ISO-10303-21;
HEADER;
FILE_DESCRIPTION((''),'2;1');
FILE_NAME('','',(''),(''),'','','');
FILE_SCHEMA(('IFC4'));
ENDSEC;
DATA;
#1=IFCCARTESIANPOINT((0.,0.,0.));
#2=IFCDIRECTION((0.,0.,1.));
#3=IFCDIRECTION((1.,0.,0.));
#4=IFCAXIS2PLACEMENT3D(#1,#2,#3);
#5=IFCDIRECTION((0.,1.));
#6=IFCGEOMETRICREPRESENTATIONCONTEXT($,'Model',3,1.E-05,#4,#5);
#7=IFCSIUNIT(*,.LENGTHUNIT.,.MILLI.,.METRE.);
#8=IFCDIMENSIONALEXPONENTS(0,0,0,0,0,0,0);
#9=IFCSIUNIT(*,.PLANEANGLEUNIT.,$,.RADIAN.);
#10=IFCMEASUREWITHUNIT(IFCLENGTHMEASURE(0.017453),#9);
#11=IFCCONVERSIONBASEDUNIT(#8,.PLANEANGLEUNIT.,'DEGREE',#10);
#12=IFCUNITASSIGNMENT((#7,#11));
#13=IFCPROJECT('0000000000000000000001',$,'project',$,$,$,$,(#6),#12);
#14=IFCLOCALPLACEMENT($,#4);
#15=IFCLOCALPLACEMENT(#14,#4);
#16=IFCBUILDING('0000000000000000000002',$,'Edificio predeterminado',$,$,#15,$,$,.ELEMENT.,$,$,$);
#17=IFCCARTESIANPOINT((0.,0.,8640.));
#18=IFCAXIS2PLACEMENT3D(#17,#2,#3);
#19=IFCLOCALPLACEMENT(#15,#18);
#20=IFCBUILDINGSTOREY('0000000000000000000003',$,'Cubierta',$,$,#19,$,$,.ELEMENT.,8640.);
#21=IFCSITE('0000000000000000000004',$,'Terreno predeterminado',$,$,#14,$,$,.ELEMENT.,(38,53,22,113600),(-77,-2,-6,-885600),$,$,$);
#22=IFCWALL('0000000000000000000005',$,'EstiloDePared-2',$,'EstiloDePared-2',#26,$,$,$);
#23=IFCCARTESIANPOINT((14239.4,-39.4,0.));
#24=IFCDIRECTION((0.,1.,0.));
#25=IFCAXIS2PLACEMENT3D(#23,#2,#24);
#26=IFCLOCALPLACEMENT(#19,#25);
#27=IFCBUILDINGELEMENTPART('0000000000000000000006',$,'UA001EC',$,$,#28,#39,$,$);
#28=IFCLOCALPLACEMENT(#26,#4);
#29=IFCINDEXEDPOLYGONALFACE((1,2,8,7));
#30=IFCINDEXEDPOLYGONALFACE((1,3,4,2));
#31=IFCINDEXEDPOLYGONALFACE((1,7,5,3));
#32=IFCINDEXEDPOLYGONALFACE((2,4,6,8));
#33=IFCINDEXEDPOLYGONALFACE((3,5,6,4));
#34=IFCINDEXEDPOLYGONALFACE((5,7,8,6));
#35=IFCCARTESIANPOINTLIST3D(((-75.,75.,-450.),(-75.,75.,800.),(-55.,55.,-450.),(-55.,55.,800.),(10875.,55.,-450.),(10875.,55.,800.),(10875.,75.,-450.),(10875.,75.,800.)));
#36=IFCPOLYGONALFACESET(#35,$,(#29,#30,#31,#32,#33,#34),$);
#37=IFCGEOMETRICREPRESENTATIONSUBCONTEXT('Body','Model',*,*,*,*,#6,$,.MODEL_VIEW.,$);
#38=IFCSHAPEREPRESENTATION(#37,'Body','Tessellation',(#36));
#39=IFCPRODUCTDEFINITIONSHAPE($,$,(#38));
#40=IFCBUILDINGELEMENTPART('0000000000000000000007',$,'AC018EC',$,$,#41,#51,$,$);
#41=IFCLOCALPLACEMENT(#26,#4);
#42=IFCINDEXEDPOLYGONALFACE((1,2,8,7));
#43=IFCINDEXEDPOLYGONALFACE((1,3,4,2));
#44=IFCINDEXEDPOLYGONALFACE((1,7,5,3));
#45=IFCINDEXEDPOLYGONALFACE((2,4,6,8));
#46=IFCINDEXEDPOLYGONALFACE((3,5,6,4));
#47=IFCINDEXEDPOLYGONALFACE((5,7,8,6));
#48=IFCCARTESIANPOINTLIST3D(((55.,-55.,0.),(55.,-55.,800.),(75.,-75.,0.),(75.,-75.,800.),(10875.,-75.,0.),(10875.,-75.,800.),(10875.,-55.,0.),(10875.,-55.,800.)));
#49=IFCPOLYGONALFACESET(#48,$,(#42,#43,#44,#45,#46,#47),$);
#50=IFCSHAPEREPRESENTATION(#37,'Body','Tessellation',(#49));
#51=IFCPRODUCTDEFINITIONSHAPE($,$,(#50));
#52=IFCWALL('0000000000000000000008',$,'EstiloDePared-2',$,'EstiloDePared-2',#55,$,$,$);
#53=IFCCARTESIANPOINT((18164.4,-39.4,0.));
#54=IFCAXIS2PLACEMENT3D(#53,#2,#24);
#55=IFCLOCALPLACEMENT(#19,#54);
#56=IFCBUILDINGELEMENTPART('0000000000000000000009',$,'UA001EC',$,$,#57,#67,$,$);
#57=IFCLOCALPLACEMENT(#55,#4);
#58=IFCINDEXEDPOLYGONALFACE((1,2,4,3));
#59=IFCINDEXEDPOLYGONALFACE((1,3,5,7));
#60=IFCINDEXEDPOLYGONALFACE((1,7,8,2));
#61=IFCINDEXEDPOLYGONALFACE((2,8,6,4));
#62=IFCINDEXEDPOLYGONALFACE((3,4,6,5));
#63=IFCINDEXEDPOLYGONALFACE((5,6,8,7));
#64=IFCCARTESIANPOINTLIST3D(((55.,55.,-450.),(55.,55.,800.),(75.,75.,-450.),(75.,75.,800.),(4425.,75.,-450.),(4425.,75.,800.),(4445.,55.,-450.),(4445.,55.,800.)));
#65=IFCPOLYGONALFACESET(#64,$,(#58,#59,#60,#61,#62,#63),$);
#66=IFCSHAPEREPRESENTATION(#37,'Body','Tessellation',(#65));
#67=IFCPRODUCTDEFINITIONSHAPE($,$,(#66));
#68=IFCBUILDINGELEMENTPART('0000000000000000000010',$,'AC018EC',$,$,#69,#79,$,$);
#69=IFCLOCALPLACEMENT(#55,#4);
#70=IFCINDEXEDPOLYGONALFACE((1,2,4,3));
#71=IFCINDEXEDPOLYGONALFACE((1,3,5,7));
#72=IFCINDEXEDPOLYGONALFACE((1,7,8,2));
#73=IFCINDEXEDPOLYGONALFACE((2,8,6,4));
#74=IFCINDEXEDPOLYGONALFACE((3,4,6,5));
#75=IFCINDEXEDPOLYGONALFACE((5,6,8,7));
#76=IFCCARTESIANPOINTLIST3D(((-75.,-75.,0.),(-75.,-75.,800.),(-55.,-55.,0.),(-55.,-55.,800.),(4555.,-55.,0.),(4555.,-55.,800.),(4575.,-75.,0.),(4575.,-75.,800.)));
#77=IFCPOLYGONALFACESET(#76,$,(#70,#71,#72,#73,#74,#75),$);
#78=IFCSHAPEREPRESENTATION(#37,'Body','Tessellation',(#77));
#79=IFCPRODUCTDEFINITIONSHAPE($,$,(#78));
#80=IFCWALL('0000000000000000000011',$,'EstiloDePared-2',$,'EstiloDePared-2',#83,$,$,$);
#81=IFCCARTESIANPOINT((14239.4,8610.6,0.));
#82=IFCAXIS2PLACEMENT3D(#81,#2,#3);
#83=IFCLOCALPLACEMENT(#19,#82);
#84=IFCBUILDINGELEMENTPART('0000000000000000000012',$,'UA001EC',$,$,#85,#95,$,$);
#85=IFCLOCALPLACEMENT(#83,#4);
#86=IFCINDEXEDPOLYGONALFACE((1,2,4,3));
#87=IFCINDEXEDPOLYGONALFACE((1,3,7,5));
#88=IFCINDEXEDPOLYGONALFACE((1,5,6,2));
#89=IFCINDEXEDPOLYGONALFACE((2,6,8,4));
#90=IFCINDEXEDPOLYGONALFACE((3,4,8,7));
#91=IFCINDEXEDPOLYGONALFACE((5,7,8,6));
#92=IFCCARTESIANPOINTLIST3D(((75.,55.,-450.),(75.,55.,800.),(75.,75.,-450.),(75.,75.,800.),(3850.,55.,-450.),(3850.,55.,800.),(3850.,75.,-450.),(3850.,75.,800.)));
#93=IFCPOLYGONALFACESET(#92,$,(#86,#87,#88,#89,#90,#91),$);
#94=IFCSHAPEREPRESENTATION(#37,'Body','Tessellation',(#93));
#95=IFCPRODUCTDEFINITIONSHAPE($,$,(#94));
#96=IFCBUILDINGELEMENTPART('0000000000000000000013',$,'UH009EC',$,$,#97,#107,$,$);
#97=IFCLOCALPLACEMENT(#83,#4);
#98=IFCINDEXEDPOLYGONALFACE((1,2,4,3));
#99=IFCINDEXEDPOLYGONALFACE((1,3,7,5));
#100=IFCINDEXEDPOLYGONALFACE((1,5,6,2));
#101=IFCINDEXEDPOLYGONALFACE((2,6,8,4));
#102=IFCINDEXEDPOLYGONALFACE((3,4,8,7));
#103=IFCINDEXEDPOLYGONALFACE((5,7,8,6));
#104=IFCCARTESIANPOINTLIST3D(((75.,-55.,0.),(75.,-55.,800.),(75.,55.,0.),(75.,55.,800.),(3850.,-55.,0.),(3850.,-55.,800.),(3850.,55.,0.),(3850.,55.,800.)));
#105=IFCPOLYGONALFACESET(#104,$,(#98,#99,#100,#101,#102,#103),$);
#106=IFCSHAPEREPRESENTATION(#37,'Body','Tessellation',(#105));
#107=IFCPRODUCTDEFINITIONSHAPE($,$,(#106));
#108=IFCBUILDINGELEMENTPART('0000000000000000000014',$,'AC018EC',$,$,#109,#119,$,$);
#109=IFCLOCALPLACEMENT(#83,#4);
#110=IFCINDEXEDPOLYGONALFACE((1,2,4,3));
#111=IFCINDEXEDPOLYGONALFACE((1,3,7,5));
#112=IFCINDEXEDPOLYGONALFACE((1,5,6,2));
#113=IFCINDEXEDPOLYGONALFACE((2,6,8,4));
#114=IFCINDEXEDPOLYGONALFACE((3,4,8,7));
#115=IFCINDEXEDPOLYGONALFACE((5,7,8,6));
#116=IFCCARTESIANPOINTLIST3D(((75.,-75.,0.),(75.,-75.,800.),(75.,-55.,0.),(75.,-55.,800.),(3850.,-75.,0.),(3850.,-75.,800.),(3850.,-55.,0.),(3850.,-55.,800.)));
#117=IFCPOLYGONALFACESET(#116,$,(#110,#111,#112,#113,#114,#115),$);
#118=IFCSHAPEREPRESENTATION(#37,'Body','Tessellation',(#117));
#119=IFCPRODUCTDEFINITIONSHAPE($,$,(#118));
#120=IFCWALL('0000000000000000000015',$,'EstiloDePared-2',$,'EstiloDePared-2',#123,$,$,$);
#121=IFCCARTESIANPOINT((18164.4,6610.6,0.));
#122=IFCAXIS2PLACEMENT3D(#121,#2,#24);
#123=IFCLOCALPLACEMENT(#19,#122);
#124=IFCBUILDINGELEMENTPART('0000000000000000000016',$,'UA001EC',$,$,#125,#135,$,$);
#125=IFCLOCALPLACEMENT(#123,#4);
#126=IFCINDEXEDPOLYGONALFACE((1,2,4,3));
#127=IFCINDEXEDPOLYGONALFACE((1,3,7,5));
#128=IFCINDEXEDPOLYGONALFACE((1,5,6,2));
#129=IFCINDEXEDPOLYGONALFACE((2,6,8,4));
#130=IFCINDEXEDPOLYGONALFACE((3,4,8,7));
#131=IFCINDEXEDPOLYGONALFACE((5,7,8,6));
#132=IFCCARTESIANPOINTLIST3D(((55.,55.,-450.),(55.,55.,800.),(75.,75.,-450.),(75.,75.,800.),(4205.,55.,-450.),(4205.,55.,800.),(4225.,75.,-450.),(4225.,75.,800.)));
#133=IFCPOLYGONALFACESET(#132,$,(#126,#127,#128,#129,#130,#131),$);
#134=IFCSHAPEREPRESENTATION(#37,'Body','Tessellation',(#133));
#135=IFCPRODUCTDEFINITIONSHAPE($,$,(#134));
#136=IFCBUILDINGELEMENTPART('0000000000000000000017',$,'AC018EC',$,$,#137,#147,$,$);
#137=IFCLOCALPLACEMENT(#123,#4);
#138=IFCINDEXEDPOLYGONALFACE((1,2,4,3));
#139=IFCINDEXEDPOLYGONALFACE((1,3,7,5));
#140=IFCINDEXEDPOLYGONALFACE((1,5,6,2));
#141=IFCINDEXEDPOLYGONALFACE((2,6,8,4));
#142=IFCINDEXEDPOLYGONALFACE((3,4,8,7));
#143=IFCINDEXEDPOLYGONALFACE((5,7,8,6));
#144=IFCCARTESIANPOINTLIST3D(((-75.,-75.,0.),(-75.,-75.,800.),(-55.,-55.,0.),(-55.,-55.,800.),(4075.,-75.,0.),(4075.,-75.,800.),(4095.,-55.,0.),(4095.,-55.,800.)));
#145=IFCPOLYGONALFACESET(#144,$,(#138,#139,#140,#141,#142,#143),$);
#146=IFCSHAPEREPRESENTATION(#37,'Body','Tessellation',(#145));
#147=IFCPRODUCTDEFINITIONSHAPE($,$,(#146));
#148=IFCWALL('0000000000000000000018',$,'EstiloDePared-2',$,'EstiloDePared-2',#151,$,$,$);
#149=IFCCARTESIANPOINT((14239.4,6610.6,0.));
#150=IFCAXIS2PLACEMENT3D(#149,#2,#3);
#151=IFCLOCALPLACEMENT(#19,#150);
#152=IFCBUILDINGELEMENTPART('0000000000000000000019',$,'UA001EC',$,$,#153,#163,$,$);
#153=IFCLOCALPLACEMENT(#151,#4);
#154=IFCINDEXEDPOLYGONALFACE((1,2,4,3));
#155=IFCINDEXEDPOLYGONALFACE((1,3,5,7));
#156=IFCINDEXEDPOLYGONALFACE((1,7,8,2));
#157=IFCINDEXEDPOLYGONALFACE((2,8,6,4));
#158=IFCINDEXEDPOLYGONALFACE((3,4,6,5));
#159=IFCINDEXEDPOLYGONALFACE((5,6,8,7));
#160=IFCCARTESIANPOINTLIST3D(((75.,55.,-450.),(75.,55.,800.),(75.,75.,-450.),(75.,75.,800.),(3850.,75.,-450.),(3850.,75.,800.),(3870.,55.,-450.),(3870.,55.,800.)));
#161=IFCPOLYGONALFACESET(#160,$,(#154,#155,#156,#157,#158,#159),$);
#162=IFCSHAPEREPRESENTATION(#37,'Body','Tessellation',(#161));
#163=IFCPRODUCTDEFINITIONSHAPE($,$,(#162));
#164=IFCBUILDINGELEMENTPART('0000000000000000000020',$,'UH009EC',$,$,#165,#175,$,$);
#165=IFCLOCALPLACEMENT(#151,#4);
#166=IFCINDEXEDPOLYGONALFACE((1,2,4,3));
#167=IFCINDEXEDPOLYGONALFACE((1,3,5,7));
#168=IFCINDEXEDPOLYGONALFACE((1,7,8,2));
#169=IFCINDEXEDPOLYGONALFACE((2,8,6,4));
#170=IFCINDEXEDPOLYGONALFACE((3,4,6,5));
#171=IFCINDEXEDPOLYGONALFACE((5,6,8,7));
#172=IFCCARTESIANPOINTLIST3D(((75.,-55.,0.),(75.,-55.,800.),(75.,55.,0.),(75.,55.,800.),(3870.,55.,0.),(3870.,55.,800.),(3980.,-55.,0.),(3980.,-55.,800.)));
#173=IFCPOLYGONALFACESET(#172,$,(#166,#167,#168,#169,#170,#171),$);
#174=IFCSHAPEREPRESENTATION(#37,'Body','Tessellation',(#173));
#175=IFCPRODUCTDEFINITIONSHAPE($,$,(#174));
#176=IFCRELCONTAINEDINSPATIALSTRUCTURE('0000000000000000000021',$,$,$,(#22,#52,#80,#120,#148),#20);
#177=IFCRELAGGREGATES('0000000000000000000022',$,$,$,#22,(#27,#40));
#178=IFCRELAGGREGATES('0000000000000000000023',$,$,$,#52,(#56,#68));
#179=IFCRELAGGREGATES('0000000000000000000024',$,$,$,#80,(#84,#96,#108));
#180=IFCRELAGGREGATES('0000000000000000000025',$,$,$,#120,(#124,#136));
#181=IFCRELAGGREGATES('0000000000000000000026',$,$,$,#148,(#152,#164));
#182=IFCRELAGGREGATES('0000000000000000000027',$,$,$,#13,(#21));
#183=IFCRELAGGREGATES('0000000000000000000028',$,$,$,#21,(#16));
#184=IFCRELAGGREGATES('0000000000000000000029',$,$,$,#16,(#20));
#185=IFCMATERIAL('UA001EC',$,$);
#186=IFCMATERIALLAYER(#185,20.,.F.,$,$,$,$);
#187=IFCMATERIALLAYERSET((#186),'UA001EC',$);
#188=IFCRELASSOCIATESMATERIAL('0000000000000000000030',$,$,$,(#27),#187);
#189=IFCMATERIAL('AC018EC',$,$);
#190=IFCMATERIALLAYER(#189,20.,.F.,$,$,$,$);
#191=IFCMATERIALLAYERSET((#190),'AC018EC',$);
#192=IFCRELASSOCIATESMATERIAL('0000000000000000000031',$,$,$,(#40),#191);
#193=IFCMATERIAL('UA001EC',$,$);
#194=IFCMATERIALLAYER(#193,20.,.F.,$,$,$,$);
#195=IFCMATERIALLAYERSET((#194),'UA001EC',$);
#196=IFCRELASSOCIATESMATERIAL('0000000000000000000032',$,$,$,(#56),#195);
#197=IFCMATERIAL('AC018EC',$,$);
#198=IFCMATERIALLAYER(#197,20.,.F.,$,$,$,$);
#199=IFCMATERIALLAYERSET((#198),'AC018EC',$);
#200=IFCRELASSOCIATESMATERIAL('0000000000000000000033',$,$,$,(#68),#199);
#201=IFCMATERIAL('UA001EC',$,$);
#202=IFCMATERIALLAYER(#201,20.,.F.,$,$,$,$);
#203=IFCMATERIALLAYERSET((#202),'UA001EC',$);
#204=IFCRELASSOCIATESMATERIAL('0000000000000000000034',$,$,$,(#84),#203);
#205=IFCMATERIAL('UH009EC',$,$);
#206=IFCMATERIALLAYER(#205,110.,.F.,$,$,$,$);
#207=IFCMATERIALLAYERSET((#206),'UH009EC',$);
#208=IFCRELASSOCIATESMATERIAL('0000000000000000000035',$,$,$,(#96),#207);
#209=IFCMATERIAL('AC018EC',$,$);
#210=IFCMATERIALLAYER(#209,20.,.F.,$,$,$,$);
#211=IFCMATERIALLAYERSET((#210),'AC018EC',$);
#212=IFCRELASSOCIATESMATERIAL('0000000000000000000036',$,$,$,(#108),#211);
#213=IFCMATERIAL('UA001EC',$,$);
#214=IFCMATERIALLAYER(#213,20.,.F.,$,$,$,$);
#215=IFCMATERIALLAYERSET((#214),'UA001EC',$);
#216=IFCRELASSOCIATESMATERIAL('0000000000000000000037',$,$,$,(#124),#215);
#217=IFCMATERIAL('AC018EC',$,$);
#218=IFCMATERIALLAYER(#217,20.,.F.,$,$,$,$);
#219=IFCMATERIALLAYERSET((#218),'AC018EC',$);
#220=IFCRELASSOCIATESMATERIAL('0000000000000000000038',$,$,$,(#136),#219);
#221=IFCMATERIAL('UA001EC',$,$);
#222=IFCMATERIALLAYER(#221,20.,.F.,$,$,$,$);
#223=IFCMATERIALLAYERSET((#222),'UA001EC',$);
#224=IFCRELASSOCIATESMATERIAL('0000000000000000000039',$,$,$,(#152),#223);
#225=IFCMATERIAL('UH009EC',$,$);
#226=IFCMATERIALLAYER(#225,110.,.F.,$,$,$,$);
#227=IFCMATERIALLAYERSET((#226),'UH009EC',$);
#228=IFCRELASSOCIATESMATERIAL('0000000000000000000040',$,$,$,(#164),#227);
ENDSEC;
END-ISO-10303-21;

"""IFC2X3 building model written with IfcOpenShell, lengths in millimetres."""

from ifc_helpers import new_model, entity, si_unit, converted_unit, direction, frame, origin_with_axes, place, context, subcontext, project, spatial, polyline, outline, extrude, material, layer, layer_set, layer_usage, element, aggregate, save


model = new_model("IFC2X3")

# Units and contexts
model_context = context("Model", 3, precision=1e-05, world=origin_with_axes(), true_north=direction((0.0, 1.0)))
body_context = subcontext(model_context, "Body", "Model", "MODEL_VIEW")
ifc_project = project(units=[si_unit("LENGTHUNIT", "METRE", prefix="MILLI"), converted_unit("PLANEANGLEUNIT", "DEGREE", entity("IfcLengthMeasure", 0.017453), si_unit("PLANEANGLEUNIT", "RADIAN"), dimensions=[0, 0, 0, 0, 0, 0, 0])], contexts=[model_context])

# Site, building, storey
site_placement = place(None, origin_with_axes())
site = spatial("IfcSite", under=ifc_project, at=site_placement, Name="Terreno predeterminado", CompositionType="ELEMENT", RefLatitude=(38, 53, 22, 113600), RefLongitude=(-77, -2, -6, -885600))
building_placement = place(site_placement, origin_with_axes())
building = spatial("IfcBuilding", under=site, at=building_placement, Name="Edificio predeterminado", CompositionType="ELEMENT")
storey_placement = place(building_placement, frame((0.0, 0.0, 8640.0), z_axis=(0.0, 0.0, 1.0), x_axis=(1.0, 0.0, 0.0)))
storey = spatial("IfcBuildingStorey", under=building, at=storey_placement, Name="Cubierta", CompositionType="ELEMENT", Elevation=8640.0)

# Walls, building element parts
wall_1_placement = place(storey_placement, frame((14239.4, -39.4, 0.0), z_axis=(0.0, 0.0, 1.0), x_axis=(0.0, 1.0, 0.0)))
wall_1 = element("IfcWall", 1, at=wall_1_placement, inside=storey, Name="EstiloDePared-2", ObjectType="EstiloDePared-2")
ifc_material_1 = material(Name="UA001EC")
ifc_layer_1 = layer(ifc_material_1, 20.0, ventilated=False)
ifc_layer_set_1 = layer_set([ifc_layer_1], Name="UA001EC")
ifc_layer_usage_1 = layer_usage(ifc_layer_set_1, "AXIS2", "NEGATIVE", -75.0)
building_element_part_1_placement = place(wall_1_placement, origin_with_axes())
building_element_part_1 = element("IfcBuildingElementPart", 2, at=building_element_part_1_placement, material=ifc_layer_usage_1, Name="UA001EC", context=body_context, shape_type="SweptSolid", body=[
    extrude(outline(polyline([(10875.0, 75.0), (10875.0, 55.0), (-55.0, 55.0), (-75.0, 75.0), (10875.0, 75.0)])), frame((0.0, 0.0, -450.0), z_axis=(0.0, 0.0, 1.0), x_axis=(1.0, 0.0, 0.0)), (0.0, 0.0, 1.0), 1250.0),
])
ifc_material_2 = material(Name="AC018EC")
ifc_layer_2 = layer(ifc_material_2, 20.0, ventilated=False)
ifc_layer_set_2 = layer_set([ifc_layer_2], Name="AC018EC")
ifc_layer_usage_2 = layer_usage(ifc_layer_set_2, "AXIS2", "NEGATIVE", 55.0)
building_element_part_2_placement = place(wall_1_placement, origin_with_axes())
building_element_part_2 = element("IfcBuildingElementPart", 3, at=building_element_part_2_placement, material=ifc_layer_usage_2, Name="AC018EC", context=body_context, shape_type="SweptSolid", body=[
    extrude(outline(polyline([(10875.0, -55.0), (10875.0, -75.0), (75.0, -75.0), (55.0, -55.0), (10875.0, -55.0)])), origin_with_axes(), (0.0, 0.0, 1.0), 800.0),
])
aggregate(wall_1, [building_element_part_1, building_element_part_2])
wall_2_placement = place(storey_placement, frame((18164.4, -39.4, 0.0), z_axis=(0.0, 0.0, 1.0), x_axis=(0.0, 1.0, 0.0)))
wall_2 = element("IfcWall", 4, at=wall_2_placement, inside=storey, Name="EstiloDePared-2", ObjectType="EstiloDePared-2")
ifc_material_3 = material(Name="UA001EC")
ifc_layer_3 = layer(ifc_material_3, 20.0, ventilated=False)
ifc_layer_set_3 = layer_set([ifc_layer_3], Name="UA001EC")
ifc_layer_usage_3 = layer_usage(ifc_layer_set_3, "AXIS2", "NEGATIVE", -75.0)
building_element_part_3_placement = place(wall_2_placement, origin_with_axes())
building_element_part_3 = element("IfcBuildingElementPart", 5, at=building_element_part_3_placement, material=ifc_layer_usage_3, Name="UA001EC", context=body_context, shape_type="SweptSolid", body=[
    extrude(outline(polyline([(4425.0, 75.0), (4445.0, 55.0), (55.0, 55.0), (75.0, 75.0), (4425.0, 75.0)])), frame((0.0, 0.0, -450.0), z_axis=(0.0, 0.0, 1.0), x_axis=(1.0, 0.0, 0.0)), (0.0, 0.0, 1.0), 1250.0),
])
ifc_material_4 = material(Name="AC018EC")
ifc_layer_4 = layer(ifc_material_4, 20.0, ventilated=False)
ifc_layer_set_4 = layer_set([ifc_layer_4], Name="AC018EC")
ifc_layer_usage_4 = layer_usage(ifc_layer_set_4, "AXIS2", "NEGATIVE", 55.0)
building_element_part_4_placement = place(wall_2_placement, origin_with_axes())
building_element_part_4 = element("IfcBuildingElementPart", 6, at=building_element_part_4_placement, material=ifc_layer_usage_4, Name="AC018EC", context=body_context, shape_type="SweptSolid", body=[
    extrude(outline(polyline([(4555.0, -55.0), (4575.0, -75.0), (-75.0, -75.0), (-55.0, -55.0), (4555.0, -55.0)])), origin_with_axes(), (0.0, 0.0, 1.0), 800.0),
])
aggregate(wall_2, [building_element_part_3, building_element_part_4])
wall_3_placement = place(storey_placement, frame((14239.4, 8610.6, 0.0), z_axis=(0.0, 0.0, 1.0), x_axis=(1.0, 0.0, 0.0)))
wall_3 = element("IfcWall", 7, at=wall_3_placement, inside=storey, Name="EstiloDePared-2", ObjectType="EstiloDePared-2")
ifc_material_5 = material(Name="UA001EC")
ifc_layer_5 = layer(ifc_material_5, 20.0, ventilated=False)
ifc_layer_set_5 = layer_set([ifc_layer_5], Name="UA001EC")
ifc_layer_usage_5 = layer_usage(ifc_layer_set_5, "AXIS2", "NEGATIVE", -75.0)
building_element_part_5_placement = place(wall_3_placement, origin_with_axes())
building_element_part_5 = element("IfcBuildingElementPart", 8, at=building_element_part_5_placement, material=ifc_layer_usage_5, Name="UA001EC", context=body_context, shape_type="SweptSolid", body=[
    extrude(outline(polyline([(3850.0, 75.0), (3850.0, 55.0), (75.0, 55.0), (75.0, 75.0), (3850.0, 75.0)])), frame((0.0, 0.0, -450.0), z_axis=(0.0, 0.0, 1.0), x_axis=(1.0, 0.0, 0.0)), (0.0, 0.0, 1.0), 1250.0),
])
ifc_material_6 = material(Name="UH009EC")
ifc_layer_6 = layer(ifc_material_6, 110.0, ventilated=False)
ifc_layer_set_6 = layer_set([ifc_layer_6], Name="UH009EC")
ifc_layer_usage_6 = layer_usage(ifc_layer_set_6, "AXIS2", "NEGATIVE", -55.0)
building_element_part_6_placement = place(wall_3_placement, origin_with_axes())
building_element_part_6 = element("IfcBuildingElementPart", 9, at=building_element_part_6_placement, material=ifc_layer_usage_6, Name="UH009EC", context=body_context, shape_type="SweptSolid", body=[
    extrude(outline(polyline([(3850.0, 55.0), (3850.0, -55.0), (75.0, -55.0), (75.0, 55.0), (3850.0, 55.0)])), origin_with_axes(), (0.0, 0.0, 1.0), 800.0),
])
ifc_material_7 = material(Name="AC018EC")
ifc_layer_7 = layer(ifc_material_7, 20.0, ventilated=False)
ifc_layer_set_7 = layer_set([ifc_layer_7], Name="AC018EC")
ifc_layer_usage_7 = layer_usage(ifc_layer_set_7, "AXIS2", "NEGATIVE", 55.0)
building_element_part_7_placement = place(wall_3_placement, origin_with_axes())
building_element_part_7 = element("IfcBuildingElementPart", 10, at=building_element_part_7_placement, material=ifc_layer_usage_7, Name="AC018EC", context=body_context, shape_type="SweptSolid", body=[
    extrude(outline(polyline([(3850.0, -55.0), (3850.0, -75.0), (75.0, -75.0), (75.0, -55.0), (3850.0, -55.0)])), origin_with_axes(), (0.0, 0.0, 1.0), 800.0),
])
aggregate(wall_3, [building_element_part_5, building_element_part_6, building_element_part_7])
wall_4_placement = place(storey_placement, frame((18164.4, 6610.6, 0.0), z_axis=(0.0, 0.0, 1.0), x_axis=(0.0, 1.0, 0.0)))
wall_4 = element("IfcWall", 11, at=wall_4_placement, inside=storey, Name="EstiloDePared-2", ObjectType="EstiloDePared-2")
ifc_material_8 = material(Name="UA001EC")
ifc_layer_8 = layer(ifc_material_8, 20.0, ventilated=False)
ifc_layer_set_8 = layer_set([ifc_layer_8], Name="UA001EC")
ifc_layer_usage_8 = layer_usage(ifc_layer_set_8, "AXIS2", "NEGATIVE", -75.0)
building_element_part_8_placement = place(wall_4_placement, origin_with_axes())
building_element_part_8 = element("IfcBuildingElementPart", 12, at=building_element_part_8_placement, material=ifc_layer_usage_8, Name="UA001EC", context=body_context, shape_type="SweptSolid", body=[
    extrude(outline(polyline([(4225.0, 75.0), (4205.0, 55.0), (55.0, 55.0), (75.0, 75.0), (4225.0, 75.0)])), frame((0.0, 0.0, -450.0), z_axis=(0.0, 0.0, 1.0), x_axis=(1.0, 0.0, 0.0)), (0.0, 0.0, 1.0), 1250.0),
])
ifc_material_9 = material(Name="AC018EC")
ifc_layer_9 = layer(ifc_material_9, 20.0, ventilated=False)
ifc_layer_set_9 = layer_set([ifc_layer_9], Name="AC018EC")
ifc_layer_usage_9 = layer_usage(ifc_layer_set_9, "AXIS2", "NEGATIVE", 55.0)
building_element_part_9_placement = place(wall_4_placement, origin_with_axes())
building_element_part_9 = element("IfcBuildingElementPart", 13, at=building_element_part_9_placement, material=ifc_layer_usage_9, Name="AC018EC", context=body_context, shape_type="SweptSolid", body=[
    extrude(outline(polyline([(4095.0, -55.0), (4075.0, -75.0), (-75.0, -75.0), (-55.0, -55.0), (4095.0, -55.0)])), origin_with_axes(), (0.0, 0.0, 1.0), 800.0),
])
aggregate(wall_4, [building_element_part_8, building_element_part_9])
wall_5_placement = place(storey_placement, frame((14239.4, 6610.6, 0.0), z_axis=(0.0, 0.0, 1.0), x_axis=(1.0, 0.0, 0.0)))
wall_5 = element("IfcWall", 14, at=wall_5_placement, inside=storey, Name="EstiloDePared-2", ObjectType="EstiloDePared-2")
ifc_material_10 = material(Name="UA001EC")
ifc_layer_10 = layer(ifc_material_10, 20.0, ventilated=False)
ifc_layer_set_10 = layer_set([ifc_layer_10], Name="UA001EC")
ifc_layer_usage_10 = layer_usage(ifc_layer_set_10, "AXIS2", "NEGATIVE", -75.0)
building_element_part_10_placement = place(wall_5_placement, origin_with_axes())
building_element_part_10 = element("IfcBuildingElementPart", 15, at=building_element_part_10_placement, material=ifc_layer_usage_10, Name="UA001EC", context=body_context, shape_type="SweptSolid", body=[
    extrude(outline(polyline([(3850.0, 75.0), (3870.0, 55.0), (75.0, 55.0), (75.0, 75.0), (3850.0, 75.0)])), frame((0.0, 0.0, -450.0), z_axis=(0.0, 0.0, 1.0), x_axis=(1.0, 0.0, 0.0)), (0.0, 0.0, 1.0), 1250.0),
])
ifc_material_11 = material(Name="UH009EC")
ifc_layer_11 = layer(ifc_material_11, 110.0, ventilated=False)
ifc_layer_set_11 = layer_set([ifc_layer_11], Name="UH009EC")
ifc_layer_usage_11 = layer_usage(ifc_layer_set_11, "AXIS2", "NEGATIVE", -55.0)
building_element_part_11_placement = place(wall_5_placement, origin_with_axes())
building_element_part_11 = element("IfcBuildingElementPart", 16, at=building_element_part_11_placement, material=ifc_layer_usage_11, Name="UH009EC", context=body_context, shape_type="SweptSolid", body=[
    extrude(outline(polyline([(3870.0, 55.0), (3980.0, -55.0), (75.0, -55.0), (75.0, 55.0), (3870.0, 55.0)])), origin_with_axes(), (0.0, 0.0, 1.0), 800.0),
])
aggregate(wall_5, [building_element_part_10, building_element_part_11])

save(model, "model.ifc")
